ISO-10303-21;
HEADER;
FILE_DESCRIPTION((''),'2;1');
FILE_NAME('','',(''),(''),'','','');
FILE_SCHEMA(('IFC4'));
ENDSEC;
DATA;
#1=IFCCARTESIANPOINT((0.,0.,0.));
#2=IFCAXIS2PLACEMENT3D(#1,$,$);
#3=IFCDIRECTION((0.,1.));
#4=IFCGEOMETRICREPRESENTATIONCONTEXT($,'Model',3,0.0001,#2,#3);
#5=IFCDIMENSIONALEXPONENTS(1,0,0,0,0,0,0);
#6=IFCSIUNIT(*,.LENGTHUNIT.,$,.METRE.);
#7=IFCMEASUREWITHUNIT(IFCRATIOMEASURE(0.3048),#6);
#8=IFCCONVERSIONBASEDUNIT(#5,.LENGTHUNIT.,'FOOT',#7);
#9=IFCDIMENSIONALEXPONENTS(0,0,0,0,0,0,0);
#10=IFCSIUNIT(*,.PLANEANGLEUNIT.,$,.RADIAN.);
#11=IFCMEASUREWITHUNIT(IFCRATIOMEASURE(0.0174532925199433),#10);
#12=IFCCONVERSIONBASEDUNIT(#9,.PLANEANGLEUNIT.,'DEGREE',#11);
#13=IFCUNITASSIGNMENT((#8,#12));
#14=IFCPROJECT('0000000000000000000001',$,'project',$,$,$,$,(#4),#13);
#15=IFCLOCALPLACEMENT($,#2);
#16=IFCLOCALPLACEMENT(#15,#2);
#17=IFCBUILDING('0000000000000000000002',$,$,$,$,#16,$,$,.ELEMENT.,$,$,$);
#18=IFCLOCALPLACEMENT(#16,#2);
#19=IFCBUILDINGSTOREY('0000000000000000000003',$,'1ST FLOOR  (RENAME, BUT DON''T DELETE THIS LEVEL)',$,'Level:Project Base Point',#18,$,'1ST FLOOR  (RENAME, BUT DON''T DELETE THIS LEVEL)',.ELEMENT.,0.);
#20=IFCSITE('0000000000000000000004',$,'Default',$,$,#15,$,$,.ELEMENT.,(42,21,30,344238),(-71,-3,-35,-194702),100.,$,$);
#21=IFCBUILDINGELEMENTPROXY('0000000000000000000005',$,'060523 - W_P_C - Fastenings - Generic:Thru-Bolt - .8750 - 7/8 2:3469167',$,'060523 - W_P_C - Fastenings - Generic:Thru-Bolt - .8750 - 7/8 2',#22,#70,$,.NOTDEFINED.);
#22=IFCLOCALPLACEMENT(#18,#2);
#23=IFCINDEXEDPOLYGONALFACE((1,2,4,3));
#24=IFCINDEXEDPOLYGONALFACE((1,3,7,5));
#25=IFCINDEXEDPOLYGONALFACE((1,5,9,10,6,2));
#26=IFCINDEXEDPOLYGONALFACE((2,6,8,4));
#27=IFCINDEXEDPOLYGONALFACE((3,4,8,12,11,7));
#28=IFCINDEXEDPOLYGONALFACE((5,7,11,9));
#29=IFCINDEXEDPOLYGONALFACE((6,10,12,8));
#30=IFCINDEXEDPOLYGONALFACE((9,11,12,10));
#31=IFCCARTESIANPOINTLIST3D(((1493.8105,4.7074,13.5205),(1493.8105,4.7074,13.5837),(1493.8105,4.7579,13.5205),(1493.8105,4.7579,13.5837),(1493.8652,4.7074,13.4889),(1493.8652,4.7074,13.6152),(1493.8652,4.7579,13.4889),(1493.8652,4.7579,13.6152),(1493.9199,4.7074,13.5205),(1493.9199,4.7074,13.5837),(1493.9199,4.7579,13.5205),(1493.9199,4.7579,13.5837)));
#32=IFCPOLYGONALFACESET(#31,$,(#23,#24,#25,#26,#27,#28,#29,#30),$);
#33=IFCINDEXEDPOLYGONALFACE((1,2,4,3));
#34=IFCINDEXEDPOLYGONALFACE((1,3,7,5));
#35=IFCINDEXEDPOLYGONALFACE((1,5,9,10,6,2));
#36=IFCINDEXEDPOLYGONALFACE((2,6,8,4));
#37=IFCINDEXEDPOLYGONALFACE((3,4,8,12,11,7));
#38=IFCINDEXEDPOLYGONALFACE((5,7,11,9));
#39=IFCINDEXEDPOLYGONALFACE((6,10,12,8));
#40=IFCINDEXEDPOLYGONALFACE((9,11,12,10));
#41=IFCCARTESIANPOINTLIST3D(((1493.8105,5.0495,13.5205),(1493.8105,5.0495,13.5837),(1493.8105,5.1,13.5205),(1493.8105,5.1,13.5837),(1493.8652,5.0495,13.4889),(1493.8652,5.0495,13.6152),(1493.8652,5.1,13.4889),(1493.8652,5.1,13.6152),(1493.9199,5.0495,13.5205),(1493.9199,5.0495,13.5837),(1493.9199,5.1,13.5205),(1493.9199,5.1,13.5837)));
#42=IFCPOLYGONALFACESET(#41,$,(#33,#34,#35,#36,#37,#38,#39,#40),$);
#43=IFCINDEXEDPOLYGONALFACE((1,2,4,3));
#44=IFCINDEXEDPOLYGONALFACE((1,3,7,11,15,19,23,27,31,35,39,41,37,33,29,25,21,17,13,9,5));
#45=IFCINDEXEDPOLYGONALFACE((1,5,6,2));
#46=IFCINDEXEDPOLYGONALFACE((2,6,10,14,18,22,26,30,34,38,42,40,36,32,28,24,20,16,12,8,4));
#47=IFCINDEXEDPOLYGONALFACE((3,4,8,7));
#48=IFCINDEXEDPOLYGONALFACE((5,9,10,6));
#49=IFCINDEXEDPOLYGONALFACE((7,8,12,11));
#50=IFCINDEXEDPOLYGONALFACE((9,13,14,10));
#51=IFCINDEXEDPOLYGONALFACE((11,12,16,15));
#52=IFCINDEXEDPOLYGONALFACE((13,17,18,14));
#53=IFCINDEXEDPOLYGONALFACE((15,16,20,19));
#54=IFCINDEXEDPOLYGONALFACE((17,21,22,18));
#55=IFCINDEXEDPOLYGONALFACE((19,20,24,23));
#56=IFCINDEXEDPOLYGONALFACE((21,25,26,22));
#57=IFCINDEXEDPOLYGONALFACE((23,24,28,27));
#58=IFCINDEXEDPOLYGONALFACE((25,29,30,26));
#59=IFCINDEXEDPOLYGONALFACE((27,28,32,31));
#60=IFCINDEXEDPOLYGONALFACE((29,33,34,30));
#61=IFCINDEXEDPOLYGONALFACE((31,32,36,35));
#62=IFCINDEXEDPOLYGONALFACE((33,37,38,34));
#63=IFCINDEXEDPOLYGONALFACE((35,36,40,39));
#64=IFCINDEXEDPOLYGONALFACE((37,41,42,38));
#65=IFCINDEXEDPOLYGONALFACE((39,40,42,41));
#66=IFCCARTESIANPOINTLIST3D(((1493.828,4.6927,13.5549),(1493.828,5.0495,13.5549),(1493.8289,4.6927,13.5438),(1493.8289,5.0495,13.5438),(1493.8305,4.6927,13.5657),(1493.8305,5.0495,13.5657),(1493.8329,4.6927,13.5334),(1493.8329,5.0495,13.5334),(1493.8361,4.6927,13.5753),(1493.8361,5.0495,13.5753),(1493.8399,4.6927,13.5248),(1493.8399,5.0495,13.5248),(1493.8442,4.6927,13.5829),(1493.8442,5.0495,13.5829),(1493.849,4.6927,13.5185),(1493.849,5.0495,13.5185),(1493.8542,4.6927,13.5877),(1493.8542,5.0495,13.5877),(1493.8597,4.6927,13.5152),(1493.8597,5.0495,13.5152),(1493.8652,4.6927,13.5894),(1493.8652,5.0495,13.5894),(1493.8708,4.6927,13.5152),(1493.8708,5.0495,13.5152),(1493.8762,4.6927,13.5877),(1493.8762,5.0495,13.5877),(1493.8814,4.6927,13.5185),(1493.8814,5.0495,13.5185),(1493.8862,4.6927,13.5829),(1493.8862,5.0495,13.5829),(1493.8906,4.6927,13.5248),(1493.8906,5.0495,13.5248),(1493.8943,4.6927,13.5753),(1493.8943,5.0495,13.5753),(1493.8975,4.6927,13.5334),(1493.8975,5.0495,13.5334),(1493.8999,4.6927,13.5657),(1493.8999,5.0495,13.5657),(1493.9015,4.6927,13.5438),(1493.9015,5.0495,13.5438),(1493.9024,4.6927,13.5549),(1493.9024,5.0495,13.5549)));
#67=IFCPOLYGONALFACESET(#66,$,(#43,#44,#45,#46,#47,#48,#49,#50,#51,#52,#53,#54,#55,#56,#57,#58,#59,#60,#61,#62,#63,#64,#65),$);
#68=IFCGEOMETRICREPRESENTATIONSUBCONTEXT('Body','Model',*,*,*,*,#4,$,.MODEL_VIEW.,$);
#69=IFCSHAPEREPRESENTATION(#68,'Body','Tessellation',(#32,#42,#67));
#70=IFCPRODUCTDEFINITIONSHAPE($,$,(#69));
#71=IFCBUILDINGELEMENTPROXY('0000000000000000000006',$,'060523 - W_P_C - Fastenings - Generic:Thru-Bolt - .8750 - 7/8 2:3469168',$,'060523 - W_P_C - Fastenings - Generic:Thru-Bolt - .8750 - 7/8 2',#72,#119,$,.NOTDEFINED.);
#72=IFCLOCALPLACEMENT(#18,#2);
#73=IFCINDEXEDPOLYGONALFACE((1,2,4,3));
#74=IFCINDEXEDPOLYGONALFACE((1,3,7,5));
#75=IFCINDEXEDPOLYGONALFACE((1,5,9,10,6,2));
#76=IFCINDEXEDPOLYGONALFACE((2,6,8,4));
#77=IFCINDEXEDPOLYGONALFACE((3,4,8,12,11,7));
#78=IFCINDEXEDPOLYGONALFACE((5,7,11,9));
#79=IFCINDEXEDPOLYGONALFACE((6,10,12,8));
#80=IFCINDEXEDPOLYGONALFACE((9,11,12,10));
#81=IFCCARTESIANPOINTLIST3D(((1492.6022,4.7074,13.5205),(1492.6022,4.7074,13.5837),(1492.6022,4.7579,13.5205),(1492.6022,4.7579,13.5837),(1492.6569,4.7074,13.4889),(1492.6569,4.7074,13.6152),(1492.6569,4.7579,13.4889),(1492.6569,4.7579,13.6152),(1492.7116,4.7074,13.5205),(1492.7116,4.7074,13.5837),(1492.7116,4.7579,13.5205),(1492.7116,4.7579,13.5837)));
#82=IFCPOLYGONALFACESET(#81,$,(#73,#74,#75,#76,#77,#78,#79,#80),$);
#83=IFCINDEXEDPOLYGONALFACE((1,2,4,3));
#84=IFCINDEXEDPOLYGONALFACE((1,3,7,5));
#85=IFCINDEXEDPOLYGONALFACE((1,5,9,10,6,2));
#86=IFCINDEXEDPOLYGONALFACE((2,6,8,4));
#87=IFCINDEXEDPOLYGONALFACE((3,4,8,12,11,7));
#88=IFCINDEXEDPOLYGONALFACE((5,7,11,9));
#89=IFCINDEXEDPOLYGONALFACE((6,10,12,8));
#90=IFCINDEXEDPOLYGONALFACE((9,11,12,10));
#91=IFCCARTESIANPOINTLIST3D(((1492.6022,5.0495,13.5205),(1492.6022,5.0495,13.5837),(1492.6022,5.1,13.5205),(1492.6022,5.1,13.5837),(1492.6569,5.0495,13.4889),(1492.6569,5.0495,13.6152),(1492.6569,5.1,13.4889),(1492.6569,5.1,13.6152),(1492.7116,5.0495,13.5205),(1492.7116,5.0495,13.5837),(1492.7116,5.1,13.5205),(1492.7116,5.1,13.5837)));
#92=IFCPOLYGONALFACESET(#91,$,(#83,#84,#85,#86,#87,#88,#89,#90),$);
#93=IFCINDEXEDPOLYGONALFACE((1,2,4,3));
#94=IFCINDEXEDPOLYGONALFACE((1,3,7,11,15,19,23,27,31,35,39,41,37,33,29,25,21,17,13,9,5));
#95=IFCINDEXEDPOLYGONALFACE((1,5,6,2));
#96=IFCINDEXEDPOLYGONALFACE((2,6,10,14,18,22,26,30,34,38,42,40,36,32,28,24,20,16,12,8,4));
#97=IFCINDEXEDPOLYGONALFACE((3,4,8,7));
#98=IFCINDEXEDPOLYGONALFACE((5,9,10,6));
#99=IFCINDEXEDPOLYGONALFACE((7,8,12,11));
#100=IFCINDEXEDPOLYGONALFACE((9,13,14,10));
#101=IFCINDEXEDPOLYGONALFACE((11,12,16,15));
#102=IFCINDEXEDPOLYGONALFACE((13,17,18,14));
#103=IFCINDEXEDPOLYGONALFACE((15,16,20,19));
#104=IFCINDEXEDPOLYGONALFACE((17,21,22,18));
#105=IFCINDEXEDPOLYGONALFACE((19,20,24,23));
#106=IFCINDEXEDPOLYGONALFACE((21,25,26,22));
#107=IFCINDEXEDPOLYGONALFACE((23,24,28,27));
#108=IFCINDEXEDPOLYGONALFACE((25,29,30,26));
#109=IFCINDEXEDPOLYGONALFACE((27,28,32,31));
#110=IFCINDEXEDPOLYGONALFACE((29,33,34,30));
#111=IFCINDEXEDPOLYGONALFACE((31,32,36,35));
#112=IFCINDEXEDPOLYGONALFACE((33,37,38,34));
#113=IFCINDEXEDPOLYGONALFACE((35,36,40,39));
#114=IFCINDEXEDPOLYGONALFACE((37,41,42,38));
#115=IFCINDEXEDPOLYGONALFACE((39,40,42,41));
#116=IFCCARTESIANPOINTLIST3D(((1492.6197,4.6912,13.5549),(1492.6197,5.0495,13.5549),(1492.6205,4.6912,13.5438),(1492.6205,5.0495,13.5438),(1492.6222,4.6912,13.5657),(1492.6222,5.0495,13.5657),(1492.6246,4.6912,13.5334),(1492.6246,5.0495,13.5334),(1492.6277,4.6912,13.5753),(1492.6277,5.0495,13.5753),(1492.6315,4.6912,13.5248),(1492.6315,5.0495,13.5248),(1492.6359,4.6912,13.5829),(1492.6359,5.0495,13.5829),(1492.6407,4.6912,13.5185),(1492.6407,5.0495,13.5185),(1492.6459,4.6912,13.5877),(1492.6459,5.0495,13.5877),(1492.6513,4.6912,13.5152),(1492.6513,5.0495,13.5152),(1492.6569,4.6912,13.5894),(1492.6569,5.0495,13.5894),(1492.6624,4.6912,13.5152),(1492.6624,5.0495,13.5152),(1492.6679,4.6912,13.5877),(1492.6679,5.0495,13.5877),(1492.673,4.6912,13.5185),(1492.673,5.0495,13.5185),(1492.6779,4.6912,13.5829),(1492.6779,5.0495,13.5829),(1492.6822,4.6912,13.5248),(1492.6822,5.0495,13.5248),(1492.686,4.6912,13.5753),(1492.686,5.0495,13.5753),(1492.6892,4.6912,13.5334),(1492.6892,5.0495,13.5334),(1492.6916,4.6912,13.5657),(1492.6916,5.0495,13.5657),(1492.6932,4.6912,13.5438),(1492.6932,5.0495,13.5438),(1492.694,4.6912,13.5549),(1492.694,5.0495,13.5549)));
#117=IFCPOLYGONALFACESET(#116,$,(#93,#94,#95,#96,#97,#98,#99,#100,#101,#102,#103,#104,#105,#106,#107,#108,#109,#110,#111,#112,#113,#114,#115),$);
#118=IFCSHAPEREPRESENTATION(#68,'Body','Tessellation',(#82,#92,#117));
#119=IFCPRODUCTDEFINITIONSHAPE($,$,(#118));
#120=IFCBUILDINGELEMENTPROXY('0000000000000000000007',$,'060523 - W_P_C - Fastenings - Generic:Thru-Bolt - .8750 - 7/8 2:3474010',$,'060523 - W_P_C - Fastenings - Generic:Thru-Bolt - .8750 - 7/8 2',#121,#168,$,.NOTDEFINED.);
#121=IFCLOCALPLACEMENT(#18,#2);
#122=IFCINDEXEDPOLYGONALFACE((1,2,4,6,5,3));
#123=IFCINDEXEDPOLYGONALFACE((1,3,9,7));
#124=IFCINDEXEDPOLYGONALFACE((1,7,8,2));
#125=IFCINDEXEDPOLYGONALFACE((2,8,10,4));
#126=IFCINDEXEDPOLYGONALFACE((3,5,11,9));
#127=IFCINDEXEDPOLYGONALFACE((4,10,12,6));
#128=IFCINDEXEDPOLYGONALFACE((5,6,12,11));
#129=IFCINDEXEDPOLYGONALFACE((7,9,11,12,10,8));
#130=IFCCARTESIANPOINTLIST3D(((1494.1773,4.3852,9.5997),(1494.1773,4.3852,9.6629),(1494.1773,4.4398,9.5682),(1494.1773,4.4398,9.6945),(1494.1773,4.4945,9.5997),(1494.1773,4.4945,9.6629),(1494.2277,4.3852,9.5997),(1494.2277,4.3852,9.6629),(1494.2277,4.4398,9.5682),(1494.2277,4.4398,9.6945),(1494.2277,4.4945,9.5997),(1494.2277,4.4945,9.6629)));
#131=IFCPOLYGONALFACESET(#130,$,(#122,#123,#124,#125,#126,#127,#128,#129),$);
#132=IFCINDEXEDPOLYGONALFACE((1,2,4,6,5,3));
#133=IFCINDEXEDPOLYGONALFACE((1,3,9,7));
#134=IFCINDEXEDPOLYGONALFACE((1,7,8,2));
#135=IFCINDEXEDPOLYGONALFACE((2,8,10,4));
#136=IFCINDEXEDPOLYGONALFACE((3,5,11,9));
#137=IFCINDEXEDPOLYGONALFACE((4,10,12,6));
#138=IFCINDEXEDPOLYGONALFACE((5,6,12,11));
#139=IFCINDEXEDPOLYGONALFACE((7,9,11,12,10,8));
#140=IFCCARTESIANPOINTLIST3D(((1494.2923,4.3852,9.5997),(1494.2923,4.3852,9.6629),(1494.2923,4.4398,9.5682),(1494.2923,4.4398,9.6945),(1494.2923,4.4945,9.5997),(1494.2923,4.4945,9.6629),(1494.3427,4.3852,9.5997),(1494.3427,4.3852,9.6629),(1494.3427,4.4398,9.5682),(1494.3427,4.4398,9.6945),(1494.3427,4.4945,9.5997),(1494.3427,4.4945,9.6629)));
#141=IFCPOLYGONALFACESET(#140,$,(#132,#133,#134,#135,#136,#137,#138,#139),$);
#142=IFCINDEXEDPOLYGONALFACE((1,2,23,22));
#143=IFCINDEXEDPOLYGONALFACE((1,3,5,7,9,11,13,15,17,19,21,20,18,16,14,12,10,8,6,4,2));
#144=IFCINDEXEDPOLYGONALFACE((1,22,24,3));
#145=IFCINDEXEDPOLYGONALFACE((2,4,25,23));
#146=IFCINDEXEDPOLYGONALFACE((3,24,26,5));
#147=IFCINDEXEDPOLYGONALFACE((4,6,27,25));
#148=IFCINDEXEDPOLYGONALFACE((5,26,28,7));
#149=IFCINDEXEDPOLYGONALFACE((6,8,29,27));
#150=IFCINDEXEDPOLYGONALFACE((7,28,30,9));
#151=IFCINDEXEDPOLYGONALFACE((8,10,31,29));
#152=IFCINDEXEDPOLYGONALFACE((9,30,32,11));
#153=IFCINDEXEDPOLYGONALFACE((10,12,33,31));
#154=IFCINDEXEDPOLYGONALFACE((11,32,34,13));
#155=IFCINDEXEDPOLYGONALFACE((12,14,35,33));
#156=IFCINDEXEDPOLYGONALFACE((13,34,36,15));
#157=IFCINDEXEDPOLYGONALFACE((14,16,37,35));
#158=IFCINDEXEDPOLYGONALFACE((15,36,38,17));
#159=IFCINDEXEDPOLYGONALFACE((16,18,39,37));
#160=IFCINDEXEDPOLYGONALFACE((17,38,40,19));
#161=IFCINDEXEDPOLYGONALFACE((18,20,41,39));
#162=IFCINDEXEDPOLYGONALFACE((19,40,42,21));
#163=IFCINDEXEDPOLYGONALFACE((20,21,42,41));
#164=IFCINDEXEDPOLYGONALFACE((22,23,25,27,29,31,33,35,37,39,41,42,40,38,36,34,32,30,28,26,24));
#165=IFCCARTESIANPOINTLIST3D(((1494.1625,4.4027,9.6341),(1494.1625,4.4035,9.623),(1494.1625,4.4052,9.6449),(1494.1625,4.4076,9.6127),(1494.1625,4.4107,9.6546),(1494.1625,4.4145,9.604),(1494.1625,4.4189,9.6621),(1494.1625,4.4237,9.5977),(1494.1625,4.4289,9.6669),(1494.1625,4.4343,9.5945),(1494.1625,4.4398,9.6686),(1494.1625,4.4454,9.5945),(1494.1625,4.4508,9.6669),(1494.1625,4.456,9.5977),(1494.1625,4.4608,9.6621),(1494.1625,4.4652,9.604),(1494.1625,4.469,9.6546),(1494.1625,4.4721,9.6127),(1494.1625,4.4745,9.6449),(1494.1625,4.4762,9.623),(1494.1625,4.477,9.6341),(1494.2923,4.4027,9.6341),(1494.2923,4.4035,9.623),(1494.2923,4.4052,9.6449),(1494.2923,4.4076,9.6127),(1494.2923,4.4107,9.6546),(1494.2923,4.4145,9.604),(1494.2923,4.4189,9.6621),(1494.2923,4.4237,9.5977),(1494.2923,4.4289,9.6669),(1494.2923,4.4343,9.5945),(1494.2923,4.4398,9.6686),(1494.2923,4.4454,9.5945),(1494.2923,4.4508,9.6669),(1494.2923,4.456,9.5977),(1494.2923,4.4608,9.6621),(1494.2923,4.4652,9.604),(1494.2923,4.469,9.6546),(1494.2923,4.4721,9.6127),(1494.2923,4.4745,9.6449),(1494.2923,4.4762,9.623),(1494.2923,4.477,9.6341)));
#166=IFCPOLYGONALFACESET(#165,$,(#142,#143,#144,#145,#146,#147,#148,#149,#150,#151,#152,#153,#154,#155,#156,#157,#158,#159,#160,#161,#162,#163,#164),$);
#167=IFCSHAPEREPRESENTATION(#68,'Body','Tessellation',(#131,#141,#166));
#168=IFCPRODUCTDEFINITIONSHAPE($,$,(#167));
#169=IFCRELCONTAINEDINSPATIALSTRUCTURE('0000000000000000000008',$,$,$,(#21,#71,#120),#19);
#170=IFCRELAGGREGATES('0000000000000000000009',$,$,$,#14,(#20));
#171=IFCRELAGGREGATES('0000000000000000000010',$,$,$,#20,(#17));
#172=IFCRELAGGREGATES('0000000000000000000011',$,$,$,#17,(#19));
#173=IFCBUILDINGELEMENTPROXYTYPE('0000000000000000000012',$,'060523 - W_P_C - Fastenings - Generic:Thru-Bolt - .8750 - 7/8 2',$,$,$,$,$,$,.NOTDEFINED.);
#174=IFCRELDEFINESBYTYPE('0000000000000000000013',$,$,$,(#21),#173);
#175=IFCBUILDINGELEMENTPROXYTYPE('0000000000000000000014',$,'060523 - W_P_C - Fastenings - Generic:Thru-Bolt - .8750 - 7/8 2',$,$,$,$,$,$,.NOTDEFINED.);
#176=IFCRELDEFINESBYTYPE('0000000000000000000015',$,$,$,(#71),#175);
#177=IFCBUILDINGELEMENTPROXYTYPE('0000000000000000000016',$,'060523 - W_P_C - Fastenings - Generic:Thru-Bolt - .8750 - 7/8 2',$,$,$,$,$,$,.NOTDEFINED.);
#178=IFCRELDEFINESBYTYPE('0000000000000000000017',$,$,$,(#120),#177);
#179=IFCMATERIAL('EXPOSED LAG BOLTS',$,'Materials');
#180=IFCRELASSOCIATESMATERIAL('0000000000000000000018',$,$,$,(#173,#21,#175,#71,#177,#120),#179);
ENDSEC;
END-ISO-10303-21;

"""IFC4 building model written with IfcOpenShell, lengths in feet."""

from ifc_helpers import new_model, entity, si_unit, converted_unit, direction, frame, frame_2d, origin, place, context, subcontext, project, spatial, polyline, circle, outline, extrude, source, transform, mapped, material, type_object, type_shapes, element, save


model = new_model("IFC4")

# Units and contexts
model_context = context("Model", 3, precision=0.0001, world=origin(), true_north=direction((0.0, 1.0)))
body_context = subcontext(model_context, "Body", "Model", "MODEL_VIEW")
ifc_project = project(units=[converted_unit("LENGTHUNIT", "FOOT", entity("IfcRatioMeasure", 0.3048), si_unit("LENGTHUNIT", "METRE"), dimensions=[1, 0, 0, 0, 0, 0, 0]), converted_unit("PLANEANGLEUNIT", "DEGREE", entity("IfcRatioMeasure", 0.0174532925199433), si_unit("PLANEANGLEUNIT", "RADIAN"), dimensions=[0, 0, 0, 0, 0, 0, 0])], contexts=[model_context])

# Site, building, storey
site_placement = place(None, origin())
site = spatial("IfcSite", under=ifc_project, at=site_placement, Name="Default", CompositionType="ELEMENT", RefLatitude=(42, 21, 30, 344238), RefLongitude=(-71, -3, -35, -194702), RefElevation=100.0)
building_placement = place(site_placement, origin())
building = spatial("IfcBuilding", under=site, at=building_placement, CompositionType="ELEMENT")
storey_placement = place(building_placement, origin())
storey = spatial("IfcBuildingStorey", under=building, at=storey_placement, Name="1ST FLOOR  (RENAME, BUT DON'T DELETE THIS LEVEL)", ObjectType="Level:Project Base Point", LongName="1ST FLOOR  (RENAME, BUT DON'T DELETE THIS LEVEL)", CompositionType="ELEMENT", Elevation=0.0)

# Building element proxies
ifc_material_1 = material(Name="EXPOSED LAG BOLTS", Category="Materials")
building_element_proxy_type_1 = type_object("IfcBuildingElementProxyType", Name="060523 - W_P_C - Fastenings - Generic:Thru-Bolt - .8750 - 7/8 2", PredefinedType="NOTDEFINED", material=ifc_material_1)
shared_shape_1 = source(origin(), body_context, "Body", "SweptSolid", [
    extrude(outline(polyline([(-0.0316, -0.0547), (0.0316, -0.0547), (0.0631, 0.0), (0.0316, 0.0547), (-0.0316, 0.0547), (-0.0631, 0.0), (-0.0316, -0.0547)])), frame((0.0, 0.0, -0.3421), z_axis=(0.0, 0.0, 1.0), x_axis=(0.866025, -0.5, 0.0)), (0.0, 0.0, 1.0), 0.0505),
    extrude(outline(polyline([(-0.0316, -0.0547), (0.0316, -0.0547), (0.0631, 0.0), (0.0316, 0.0547), (-0.0316, 0.0547), (-0.0631, 0.0), (-0.0316, -0.0547)])), frame((0.0, 0.0, 0.0), z_axis=(0.0, 0.0, 1.0), x_axis=(0.0, -1.0, 0.0)), (0.0, 0.0, 1.0), 0.0505),
    extrude(circle(Radius=0.0373, at=frame_2d((0.0, 0.0), x_axis=(1.0, 0.0))), frame((0.0, 0.0, -0.3568), z_axis=(0.0, 0.0, 1.0), x_axis=(0.0, 1.0, 0.0)), (0.0, 0.0, 1.0), 0.3568),
])
type_shapes(building_element_proxy_type_1, [shared_shape_1])
proxy_1_placement = place(storey_placement, frame((1493.8652, 5.0495, 13.5521), z_axis=(0.0, 1.0, 0.0), x_axis=(-1.0, 0.0, 0.0)))
element("IfcBuildingElementProxy", 1, at=proxy_1_placement, inside=storey, type_object=building_element_proxy_type_1, material=ifc_material_1, Name="060523 - W_P_C - Fastenings - Generic:Thru-Bolt - .8750 - 7/8 2:3469167", ObjectType="060523 - W_P_C - Fastenings - Generic:Thru-Bolt - .8750 - 7/8 2", PredefinedType="NOTDEFINED", context=body_context, shape_type="MappedRepresentation", body=[
    mapped(shared_shape_1, transform((0.0, 0.0, 0.0), scale=1.0)),
])
building_element_proxy_type_2 = type_object("IfcBuildingElementProxyType", Name="060523 - W_P_C - Fastenings - Generic:Thru-Bolt - .8750 - 7/8 2", PredefinedType="NOTDEFINED", material=ifc_material_1)
shared_shape_2 = source(origin(), body_context, "Body", "SweptSolid", [
    extrude(outline(polyline([(-0.0316, -0.0547), (0.0316, -0.0547), (0.0631, 0.0), (0.0316, 0.0547), (-0.0316, 0.0547), (-0.0631, 0.0), (-0.0316, -0.0547)])), frame((0.0, 0.0, -0.3421), z_axis=(0.0, 0.0, 1.0), x_axis=(0.866025, -0.5, 0.0)), (0.0, 0.0, 1.0), 0.0505),
    extrude(outline(polyline([(-0.0316, -0.0547), (0.0316, -0.0547), (0.0631, 0.0), (0.0316, 0.0547), (-0.0316, 0.0547), (-0.0631, 0.0), (-0.0316, -0.0547)])), frame((0.0, 0.0, 0.0), z_axis=(0.0, 0.0, 1.0), x_axis=(0.0, -1.0, 0.0)), (0.0, 0.0, 1.0), 0.0505),
    extrude(circle(Radius=0.0373, at=frame_2d((0.0, 0.0), x_axis=(1.0, 0.0))), frame((0.0, 0.0, -0.3583), z_axis=(0.0, 0.0, 1.0), x_axis=(0.0, 1.0, 0.0)), (0.0, 0.0, 1.0), 0.3583),
])
type_shapes(building_element_proxy_type_2, [shared_shape_2])
proxy_2_placement = place(storey_placement, frame((1492.6569, 5.0495, 13.5521), z_axis=(0.0, 1.0, 0.0), x_axis=(-1.0, 0.0, 0.0)))
element("IfcBuildingElementProxy", 2, at=proxy_2_placement, inside=storey, type_object=building_element_proxy_type_2, material=ifc_material_1, Name="060523 - W_P_C - Fastenings - Generic:Thru-Bolt - .8750 - 7/8 2:3469168", ObjectType="060523 - W_P_C - Fastenings - Generic:Thru-Bolt - .8750 - 7/8 2", PredefinedType="NOTDEFINED", context=body_context, shape_type="MappedRepresentation", body=[
    mapped(shared_shape_2, transform((0.0, 0.0, 0.0), scale=1.0)),
])
building_element_proxy_type_3 = type_object("IfcBuildingElementProxyType", Name="060523 - W_P_C - Fastenings - Generic:Thru-Bolt - .8750 - 7/8 2", PredefinedType="NOTDEFINED", material=ifc_material_1)
shared_shape_3 = source(origin(), body_context, "Body", "SweptSolid", [
    extrude(outline(polyline([(-0.0316, -0.0547), (0.0316, -0.0547), (0.0631, 0.0), (0.0316, 0.0547), (-0.0316, 0.0547), (-0.0631, 0.0), (-0.0316, -0.0547)])), frame((0.0, 0.0, -0.115), z_axis=(0.0, 0.0, 1.0), x_axis=(0.866025, -0.5, 0.0)), (0.0, 0.0, 1.0), 0.0505),
    extrude(outline(polyline([(-0.0316, -0.0547), (0.0316, -0.0547), (0.0631, 0.0), (0.0316, 0.0547), (-0.0316, 0.0547), (-0.0631, 0.0), (-0.0316, -0.0547)])), frame((0.0, 0.0, 0.0), z_axis=(0.0, 0.0, 1.0), x_axis=(0.0, -1.0, 0.0)), (0.0, 0.0, 1.0), 0.0505),
    extrude(circle(Radius=0.0373, at=frame_2d((0.0, 0.0), x_axis=(1.0, 0.0))), frame((0.0, 0.0, -0.1298), z_axis=(0.0, 0.0, 1.0), x_axis=(0.0, 1.0, 0.0)), (0.0, 0.0, 1.0), 0.1298),
])
type_shapes(building_element_proxy_type_3, [shared_shape_3])
proxy_3_placement = place(storey_placement, frame((1494.2923, 4.4398, 9.6313), z_axis=(1.0, 0.0, 0.0), x_axis=(0.0, 1.0, 0.0)))
element("IfcBuildingElementProxy", 3, at=proxy_3_placement, inside=storey, type_object=building_element_proxy_type_3, material=ifc_material_1, Name="060523 - W_P_C - Fastenings - Generic:Thru-Bolt - .8750 - 7/8 2:3474010", ObjectType="060523 - W_P_C - Fastenings - Generic:Thru-Bolt - .8750 - 7/8 2", PredefinedType="NOTDEFINED", context=body_context, shape_type="MappedRepresentation", body=[
    mapped(shared_shape_3, transform((0.0, 0.0, 0.0), scale=1.0)),
])

save(model, "model.ifc")
